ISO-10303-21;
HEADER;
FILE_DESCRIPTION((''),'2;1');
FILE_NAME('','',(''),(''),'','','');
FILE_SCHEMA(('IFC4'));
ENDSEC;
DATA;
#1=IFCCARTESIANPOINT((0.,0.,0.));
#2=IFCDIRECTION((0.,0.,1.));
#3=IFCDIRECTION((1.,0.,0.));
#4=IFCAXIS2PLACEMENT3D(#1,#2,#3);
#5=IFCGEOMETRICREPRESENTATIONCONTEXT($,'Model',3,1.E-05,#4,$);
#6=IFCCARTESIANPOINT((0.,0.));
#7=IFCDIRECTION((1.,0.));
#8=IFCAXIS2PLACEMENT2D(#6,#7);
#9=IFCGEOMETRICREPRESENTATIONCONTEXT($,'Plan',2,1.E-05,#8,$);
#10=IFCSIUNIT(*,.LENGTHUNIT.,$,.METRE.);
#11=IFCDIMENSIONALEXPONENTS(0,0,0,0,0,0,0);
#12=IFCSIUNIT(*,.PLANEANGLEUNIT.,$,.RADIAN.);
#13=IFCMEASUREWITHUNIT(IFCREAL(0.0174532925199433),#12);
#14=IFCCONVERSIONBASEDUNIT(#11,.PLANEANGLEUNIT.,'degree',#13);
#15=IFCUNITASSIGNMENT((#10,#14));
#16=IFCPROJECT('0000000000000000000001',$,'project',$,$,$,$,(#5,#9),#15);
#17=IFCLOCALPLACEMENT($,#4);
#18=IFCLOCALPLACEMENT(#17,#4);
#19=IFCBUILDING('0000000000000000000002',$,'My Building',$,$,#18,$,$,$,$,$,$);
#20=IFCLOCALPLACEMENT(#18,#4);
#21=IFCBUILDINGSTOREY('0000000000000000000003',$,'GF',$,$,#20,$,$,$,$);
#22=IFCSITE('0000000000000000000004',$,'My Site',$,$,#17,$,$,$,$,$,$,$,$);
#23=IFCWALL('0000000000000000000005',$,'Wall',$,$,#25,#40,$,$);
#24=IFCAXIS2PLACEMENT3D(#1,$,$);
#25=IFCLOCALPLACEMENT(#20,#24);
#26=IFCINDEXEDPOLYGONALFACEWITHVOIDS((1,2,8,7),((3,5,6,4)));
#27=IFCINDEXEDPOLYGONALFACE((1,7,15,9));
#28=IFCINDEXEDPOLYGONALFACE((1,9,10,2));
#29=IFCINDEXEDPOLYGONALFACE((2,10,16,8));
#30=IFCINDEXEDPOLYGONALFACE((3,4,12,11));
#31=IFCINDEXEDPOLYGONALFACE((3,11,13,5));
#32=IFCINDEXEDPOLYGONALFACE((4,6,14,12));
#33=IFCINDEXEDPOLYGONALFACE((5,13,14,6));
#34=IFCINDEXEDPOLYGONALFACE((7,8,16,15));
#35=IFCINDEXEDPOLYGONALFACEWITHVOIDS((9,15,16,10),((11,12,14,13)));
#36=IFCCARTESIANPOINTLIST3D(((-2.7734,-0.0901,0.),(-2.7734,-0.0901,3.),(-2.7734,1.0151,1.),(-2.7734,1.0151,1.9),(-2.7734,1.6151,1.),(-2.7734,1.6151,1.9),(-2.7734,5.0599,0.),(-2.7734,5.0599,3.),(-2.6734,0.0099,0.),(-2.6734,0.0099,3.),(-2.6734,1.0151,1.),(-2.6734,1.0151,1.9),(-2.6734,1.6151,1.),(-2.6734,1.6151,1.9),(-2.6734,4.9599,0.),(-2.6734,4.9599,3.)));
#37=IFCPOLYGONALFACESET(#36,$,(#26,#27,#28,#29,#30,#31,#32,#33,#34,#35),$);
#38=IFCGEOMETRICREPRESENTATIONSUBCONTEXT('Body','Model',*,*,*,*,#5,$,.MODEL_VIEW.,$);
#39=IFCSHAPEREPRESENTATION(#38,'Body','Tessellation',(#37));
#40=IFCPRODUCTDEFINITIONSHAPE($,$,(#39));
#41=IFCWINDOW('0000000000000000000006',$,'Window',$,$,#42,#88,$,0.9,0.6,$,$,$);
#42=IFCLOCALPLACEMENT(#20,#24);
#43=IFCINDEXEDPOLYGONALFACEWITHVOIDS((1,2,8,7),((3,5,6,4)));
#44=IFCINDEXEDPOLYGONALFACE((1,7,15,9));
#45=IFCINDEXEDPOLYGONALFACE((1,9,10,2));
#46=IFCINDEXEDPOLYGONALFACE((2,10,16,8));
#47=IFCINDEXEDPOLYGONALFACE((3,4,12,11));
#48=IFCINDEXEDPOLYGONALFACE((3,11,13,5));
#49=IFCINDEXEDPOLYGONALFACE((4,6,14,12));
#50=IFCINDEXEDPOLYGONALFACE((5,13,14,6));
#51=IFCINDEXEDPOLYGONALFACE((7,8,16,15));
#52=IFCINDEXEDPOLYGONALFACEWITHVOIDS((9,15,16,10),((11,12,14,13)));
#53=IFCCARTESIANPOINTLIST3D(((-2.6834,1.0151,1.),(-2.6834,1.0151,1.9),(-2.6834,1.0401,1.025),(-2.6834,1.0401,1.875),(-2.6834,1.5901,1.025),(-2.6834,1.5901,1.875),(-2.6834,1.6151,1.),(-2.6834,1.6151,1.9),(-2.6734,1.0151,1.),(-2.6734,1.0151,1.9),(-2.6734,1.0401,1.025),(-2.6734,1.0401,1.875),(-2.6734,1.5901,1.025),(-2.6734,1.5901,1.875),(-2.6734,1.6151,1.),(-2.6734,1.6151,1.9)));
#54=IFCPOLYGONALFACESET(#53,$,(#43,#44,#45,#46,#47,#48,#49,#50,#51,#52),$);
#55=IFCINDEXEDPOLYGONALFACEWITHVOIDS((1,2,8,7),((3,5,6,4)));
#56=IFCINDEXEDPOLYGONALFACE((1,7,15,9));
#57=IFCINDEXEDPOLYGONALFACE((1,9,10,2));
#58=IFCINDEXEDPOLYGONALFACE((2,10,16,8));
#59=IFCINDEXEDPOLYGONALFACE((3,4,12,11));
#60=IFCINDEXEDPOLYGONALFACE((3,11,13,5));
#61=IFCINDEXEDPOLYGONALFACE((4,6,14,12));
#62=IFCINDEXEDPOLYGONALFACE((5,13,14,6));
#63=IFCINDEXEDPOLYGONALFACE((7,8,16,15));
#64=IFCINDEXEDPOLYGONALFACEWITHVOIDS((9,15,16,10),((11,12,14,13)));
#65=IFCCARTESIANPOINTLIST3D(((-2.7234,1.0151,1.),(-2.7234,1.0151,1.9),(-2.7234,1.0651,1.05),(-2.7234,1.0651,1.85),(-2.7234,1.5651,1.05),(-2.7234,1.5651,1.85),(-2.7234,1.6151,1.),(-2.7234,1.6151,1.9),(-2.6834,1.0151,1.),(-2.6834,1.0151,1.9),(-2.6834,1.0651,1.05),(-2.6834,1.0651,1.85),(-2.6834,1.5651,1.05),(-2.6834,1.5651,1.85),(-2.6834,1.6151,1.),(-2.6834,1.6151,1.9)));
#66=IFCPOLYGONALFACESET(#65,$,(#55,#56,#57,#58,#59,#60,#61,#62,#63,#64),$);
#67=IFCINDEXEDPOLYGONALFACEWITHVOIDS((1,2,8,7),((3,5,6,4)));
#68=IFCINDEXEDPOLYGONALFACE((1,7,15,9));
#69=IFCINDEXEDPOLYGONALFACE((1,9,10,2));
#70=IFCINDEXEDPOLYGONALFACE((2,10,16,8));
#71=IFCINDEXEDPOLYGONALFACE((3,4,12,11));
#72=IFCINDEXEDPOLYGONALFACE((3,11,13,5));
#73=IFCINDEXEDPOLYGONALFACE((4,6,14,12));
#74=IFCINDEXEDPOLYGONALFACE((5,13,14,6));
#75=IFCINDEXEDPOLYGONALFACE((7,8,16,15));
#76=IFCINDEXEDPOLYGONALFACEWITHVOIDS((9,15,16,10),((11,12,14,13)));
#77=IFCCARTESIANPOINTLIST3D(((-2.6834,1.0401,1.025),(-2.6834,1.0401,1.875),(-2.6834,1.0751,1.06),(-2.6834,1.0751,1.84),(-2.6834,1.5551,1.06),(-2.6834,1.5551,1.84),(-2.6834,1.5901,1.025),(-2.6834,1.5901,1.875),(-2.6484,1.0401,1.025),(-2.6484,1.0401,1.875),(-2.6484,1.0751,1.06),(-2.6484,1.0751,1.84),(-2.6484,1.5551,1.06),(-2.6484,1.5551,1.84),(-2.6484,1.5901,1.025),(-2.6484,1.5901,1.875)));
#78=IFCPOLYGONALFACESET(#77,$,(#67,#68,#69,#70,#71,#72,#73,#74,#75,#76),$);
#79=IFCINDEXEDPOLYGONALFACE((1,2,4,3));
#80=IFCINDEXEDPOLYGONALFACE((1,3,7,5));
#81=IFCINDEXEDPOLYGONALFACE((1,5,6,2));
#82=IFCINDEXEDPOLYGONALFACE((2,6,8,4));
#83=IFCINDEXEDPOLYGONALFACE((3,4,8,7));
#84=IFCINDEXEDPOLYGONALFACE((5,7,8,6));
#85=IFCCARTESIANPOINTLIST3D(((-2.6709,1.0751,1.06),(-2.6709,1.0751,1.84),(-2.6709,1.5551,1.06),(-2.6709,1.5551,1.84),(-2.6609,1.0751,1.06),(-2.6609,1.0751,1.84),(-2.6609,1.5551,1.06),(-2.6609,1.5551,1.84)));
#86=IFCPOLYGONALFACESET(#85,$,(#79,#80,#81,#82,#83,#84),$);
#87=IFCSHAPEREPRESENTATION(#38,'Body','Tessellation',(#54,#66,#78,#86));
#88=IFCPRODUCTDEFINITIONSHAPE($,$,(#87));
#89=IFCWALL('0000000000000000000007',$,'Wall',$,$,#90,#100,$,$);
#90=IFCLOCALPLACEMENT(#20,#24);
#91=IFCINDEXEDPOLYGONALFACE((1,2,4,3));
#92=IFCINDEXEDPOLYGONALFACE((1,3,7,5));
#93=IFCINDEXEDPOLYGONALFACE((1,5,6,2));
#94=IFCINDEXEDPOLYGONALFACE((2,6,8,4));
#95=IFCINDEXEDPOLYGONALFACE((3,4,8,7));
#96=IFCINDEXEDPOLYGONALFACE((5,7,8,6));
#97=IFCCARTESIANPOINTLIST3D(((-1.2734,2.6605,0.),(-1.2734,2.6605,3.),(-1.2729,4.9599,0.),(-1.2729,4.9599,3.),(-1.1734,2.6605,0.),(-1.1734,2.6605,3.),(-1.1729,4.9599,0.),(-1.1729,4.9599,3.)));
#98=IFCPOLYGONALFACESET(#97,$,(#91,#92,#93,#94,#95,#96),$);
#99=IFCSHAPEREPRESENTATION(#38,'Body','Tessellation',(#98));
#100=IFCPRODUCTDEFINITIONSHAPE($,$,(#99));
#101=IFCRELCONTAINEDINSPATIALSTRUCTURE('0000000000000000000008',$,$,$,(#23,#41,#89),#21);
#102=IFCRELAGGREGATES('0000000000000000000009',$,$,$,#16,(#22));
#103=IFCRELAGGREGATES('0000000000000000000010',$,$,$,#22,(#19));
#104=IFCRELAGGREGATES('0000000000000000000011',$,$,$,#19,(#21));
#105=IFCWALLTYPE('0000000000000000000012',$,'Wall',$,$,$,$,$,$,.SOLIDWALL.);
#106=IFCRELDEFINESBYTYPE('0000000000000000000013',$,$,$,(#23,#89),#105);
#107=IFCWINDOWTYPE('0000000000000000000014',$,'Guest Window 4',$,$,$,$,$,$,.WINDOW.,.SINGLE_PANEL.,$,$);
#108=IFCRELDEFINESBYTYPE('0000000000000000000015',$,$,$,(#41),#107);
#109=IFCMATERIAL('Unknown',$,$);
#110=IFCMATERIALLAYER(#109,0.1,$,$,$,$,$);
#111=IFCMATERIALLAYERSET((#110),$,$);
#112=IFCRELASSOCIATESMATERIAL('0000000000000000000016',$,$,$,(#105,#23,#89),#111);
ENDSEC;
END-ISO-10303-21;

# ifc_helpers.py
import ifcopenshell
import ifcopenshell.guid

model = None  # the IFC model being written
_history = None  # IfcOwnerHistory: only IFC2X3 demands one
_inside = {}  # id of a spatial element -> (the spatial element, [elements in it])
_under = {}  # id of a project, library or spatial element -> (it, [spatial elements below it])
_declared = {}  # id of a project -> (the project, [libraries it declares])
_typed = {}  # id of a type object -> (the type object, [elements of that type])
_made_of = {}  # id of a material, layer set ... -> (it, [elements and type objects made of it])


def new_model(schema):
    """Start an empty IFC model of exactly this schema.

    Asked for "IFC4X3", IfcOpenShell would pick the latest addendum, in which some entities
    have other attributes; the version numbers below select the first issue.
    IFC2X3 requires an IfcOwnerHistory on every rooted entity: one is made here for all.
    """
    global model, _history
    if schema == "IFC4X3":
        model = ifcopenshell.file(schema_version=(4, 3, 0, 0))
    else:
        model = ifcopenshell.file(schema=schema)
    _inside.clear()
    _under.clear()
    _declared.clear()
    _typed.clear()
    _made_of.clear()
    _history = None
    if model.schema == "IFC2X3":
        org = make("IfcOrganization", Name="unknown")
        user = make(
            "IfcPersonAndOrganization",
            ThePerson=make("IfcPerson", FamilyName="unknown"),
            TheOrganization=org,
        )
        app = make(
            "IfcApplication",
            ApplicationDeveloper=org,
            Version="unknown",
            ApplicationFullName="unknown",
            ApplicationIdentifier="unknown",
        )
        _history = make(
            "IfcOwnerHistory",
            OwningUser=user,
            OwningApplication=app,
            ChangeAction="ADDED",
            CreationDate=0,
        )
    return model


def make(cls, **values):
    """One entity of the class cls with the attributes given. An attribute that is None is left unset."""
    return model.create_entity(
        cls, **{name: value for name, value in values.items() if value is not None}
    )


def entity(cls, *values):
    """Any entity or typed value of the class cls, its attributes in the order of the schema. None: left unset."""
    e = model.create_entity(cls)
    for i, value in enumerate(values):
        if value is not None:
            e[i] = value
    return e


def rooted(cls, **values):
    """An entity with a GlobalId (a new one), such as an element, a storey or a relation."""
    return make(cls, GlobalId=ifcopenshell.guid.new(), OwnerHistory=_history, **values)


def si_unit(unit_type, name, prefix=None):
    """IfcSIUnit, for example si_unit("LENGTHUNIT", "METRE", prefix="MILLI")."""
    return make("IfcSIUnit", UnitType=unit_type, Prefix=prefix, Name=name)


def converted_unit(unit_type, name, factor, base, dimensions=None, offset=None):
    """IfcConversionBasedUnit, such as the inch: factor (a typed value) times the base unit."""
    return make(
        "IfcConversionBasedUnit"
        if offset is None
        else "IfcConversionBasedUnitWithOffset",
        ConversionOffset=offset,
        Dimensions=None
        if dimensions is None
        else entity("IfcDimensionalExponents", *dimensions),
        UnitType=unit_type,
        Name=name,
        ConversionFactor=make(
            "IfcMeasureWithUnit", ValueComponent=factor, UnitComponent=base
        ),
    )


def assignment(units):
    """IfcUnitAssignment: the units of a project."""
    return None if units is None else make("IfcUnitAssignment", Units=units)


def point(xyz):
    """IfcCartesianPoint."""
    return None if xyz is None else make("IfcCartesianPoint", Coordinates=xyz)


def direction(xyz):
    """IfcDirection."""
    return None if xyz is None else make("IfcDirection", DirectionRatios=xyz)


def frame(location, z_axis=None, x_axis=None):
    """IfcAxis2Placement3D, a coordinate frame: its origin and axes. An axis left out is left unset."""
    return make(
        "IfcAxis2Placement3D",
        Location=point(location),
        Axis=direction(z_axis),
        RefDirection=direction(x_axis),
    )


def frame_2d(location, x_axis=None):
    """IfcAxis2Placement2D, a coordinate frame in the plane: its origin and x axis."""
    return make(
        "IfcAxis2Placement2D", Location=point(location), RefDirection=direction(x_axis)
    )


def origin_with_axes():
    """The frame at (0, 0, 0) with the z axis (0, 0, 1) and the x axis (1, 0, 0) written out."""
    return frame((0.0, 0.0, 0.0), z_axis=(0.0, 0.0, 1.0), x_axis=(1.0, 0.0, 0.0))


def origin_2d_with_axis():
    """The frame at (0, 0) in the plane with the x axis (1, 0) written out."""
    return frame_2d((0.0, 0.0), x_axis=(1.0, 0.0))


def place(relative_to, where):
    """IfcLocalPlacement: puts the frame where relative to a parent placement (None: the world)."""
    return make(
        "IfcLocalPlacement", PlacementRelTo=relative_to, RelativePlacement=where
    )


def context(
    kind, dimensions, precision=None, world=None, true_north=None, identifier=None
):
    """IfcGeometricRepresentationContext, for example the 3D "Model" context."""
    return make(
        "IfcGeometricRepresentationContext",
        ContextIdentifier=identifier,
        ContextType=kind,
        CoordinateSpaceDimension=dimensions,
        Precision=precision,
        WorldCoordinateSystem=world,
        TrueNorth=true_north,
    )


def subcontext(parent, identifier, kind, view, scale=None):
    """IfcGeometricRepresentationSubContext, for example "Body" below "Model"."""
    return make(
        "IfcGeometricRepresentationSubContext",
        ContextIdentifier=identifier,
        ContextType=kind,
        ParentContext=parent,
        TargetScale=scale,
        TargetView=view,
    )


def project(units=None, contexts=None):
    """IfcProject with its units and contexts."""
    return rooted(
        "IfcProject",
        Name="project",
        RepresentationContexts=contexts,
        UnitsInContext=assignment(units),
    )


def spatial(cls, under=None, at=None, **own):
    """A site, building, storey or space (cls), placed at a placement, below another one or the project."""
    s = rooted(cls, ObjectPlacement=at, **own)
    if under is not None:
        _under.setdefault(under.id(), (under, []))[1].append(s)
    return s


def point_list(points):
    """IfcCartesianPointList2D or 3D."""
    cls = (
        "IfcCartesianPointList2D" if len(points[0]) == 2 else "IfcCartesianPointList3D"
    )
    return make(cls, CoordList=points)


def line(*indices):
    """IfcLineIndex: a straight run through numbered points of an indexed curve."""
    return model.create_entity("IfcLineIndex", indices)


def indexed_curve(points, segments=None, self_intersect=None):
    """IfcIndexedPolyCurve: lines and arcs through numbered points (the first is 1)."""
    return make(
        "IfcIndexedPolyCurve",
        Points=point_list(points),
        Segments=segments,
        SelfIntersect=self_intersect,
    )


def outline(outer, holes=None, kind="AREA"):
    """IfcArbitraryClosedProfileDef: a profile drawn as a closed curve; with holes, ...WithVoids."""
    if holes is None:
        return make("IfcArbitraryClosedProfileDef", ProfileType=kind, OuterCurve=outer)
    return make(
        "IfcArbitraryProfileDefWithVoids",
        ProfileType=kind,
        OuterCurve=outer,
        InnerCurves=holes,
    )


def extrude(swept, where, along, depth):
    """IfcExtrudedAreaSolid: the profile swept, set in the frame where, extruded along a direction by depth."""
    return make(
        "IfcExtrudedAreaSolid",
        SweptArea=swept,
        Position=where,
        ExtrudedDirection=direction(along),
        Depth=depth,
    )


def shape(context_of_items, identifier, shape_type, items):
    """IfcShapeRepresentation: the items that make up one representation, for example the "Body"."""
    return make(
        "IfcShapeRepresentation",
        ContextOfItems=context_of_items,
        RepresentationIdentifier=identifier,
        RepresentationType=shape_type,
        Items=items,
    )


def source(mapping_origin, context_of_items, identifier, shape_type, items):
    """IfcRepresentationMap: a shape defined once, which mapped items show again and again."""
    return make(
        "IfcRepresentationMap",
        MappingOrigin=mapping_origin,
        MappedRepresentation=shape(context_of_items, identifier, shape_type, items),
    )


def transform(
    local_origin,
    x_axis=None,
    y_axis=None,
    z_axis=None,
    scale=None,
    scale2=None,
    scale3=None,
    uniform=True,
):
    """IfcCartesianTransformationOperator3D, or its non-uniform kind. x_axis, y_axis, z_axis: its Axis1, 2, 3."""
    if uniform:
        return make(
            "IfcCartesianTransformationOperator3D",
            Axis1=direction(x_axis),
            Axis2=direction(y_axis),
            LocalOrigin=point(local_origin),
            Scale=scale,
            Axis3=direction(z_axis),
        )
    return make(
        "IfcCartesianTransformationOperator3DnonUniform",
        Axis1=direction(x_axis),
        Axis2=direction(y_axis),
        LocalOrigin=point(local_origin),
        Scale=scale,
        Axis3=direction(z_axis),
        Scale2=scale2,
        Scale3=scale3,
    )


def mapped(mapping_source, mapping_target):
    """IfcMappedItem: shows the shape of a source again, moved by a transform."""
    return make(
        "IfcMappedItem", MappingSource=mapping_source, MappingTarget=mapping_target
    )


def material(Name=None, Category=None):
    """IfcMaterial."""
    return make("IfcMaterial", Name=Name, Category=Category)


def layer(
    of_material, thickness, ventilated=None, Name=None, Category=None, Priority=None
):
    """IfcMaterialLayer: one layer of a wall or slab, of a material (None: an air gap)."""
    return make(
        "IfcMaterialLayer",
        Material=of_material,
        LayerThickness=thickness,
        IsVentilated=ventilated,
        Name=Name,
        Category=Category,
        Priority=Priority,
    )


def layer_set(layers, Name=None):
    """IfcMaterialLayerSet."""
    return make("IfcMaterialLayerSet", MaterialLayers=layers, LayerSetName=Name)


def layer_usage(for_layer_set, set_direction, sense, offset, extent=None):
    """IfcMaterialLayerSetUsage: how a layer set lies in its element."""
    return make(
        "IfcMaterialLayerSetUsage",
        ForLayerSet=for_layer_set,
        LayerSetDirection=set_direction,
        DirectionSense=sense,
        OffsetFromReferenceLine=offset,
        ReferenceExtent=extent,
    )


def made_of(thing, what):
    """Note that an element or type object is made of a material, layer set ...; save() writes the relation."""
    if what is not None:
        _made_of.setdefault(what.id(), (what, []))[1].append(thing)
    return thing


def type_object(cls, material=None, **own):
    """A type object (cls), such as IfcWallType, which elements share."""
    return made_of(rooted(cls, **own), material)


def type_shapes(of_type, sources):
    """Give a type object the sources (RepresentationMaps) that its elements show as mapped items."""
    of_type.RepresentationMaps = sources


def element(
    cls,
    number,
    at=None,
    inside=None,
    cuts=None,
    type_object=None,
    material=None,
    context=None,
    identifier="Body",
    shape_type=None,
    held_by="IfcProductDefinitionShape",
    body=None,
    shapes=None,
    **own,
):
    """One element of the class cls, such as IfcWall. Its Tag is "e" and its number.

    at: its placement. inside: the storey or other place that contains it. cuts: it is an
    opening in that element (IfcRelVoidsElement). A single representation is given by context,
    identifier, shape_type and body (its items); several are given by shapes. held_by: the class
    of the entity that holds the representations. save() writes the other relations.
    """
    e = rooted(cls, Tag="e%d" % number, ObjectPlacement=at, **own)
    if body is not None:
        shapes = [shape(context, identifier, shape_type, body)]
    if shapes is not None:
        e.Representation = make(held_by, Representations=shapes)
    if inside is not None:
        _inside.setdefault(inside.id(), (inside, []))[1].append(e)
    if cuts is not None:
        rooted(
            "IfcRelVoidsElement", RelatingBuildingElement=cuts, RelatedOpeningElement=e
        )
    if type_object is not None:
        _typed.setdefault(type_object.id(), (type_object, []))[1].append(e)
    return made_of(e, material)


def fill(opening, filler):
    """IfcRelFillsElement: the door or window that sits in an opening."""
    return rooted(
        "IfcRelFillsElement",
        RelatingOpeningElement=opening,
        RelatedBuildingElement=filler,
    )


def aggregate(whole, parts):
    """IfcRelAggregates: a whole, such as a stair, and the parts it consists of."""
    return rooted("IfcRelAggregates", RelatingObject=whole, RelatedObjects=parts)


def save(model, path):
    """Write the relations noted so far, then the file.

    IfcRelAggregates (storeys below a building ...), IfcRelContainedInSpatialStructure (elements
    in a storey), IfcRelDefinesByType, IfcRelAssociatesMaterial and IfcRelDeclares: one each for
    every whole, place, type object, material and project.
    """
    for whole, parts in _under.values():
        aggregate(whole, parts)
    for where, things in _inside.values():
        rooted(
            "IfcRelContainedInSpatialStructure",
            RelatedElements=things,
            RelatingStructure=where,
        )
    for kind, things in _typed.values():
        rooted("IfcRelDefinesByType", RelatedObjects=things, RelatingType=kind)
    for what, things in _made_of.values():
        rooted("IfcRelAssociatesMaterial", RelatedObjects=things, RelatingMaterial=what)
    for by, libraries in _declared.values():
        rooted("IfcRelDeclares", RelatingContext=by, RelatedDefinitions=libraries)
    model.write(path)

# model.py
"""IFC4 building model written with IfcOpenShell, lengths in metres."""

from ifc_helpers import new_model, entity, si_unit, converted_unit, frame, origin_with_axes, origin_2d_with_axis, place, context, subcontext, project, spatial, line, indexed_curve, outline, extrude, shape, source, transform, mapped, material, layer, layer_set, layer_usage, type_object, type_shapes, element, fill, save


model = new_model("IFC4")

# Units and contexts
model_context = context("Model", 3, precision=1e-05, world=origin_with_axes())
plan_context = context("Plan", 2, precision=1e-05, world=origin_2d_with_axis())
body_context_1 = subcontext(model_context, "Body", "Model", "MODEL_VIEW")
body_context_2 = subcontext(plan_context, "Body", "Plan", "PLAN_VIEW")
ifc_project = project(units=[si_unit("LENGTHUNIT", "METRE"), converted_unit("PLANEANGLEUNIT", "degree", entity("IfcReal", 0.0174532925199433), si_unit("PLANEANGLEUNIT", "RADIAN"), dimensions=[0, 0, 0, 0, 0, 0, 0])], contexts=[model_context, plan_context])

# Site, building, storey
site_placement = place(None, origin_with_axes())
site = spatial("IfcSite", under=ifc_project, at=site_placement, Name="My Site")
building_placement = place(site_placement, origin_with_axes())
building = spatial("IfcBuilding", under=site, at=building_placement, Name="My Building")
storey_placement = place(building_placement, origin_with_axes())
storey = spatial("IfcBuildingStorey", under=building, at=storey_placement, Name="GF")

# Shared definitions
ifc_material = material(Name="Unknown")

# Shared definitions
ifc_layer = layer(ifc_material, 0.1)
ifc_layer_set = layer_set([ifc_layer])
wall_type = type_object("IfcWallType", Name="Wall", PredefinedType="SOLIDWALL", material=ifc_layer_set)

# Wall, opening, window
ifc_layer_usage_1 = layer_usage(ifc_layer_set, "AXIS2", "POSITIVE", 0.0)
wall_1_placement = place(storey_placement, frame((-2.7734, 5.0599, 0.0), z_axis=(0.0, 0.0, 1.0), x_axis=(0.0, -1.0, 0.0)))
wall_1 = element("IfcWall", 1, at=wall_1_placement, inside=storey, type_object=wall_type, material=ifc_layer_usage_1, Name="Wall", context=body_context_1, shape_type="SweptSolid", body=[
    extrude(outline(indexed_curve([(0.0, 0.0), (0.1, 0.1), (5.05, 0.1), (5.15, 0.0)], segments=[line(1, 2, 3, 4, 1)])), origin_with_axes(), (0.0, 0.0, 1.0), 3.0),
])
shared_shape_1 = source(origin_with_axes(), body_context_1, "Body", "SweptSolid", [
    extrude(outline(indexed_curve([(0.0, 0.0), (0.6, 0.0), (0.6, 0.9), (0.0, 0.9)], segments=[line(1, 2, 3, 4, 1)])), frame((0.0, -0.6, 0.0), z_axis=(0.0, -1.0, 0.0), x_axis=(1.0, 0.0, 0.0)), (0.0, 0.0, -1.0), 1.2),
])
opening_1_placement = place(wall_1_placement, frame((3.4448, 0.0, 1.0), z_axis=(0.0, 0.0, 1.0), x_axis=(1.0, 0.0, 0.0)))
opening_1 = element("IfcOpeningElement", 2, at=opening_1_placement, cuts=wall_1, PredefinedType="OPENING", context=body_context_1, shape_type="MappedRepresentation", body=[
    mapped(shared_shape_1, transform((0.0, 0.0, 0.0), x_axis=(1.0, 0.0, 0.0), y_axis=(0.0, 1.0, 0.0), z_axis=(0.0, 0.0, 1.0), scale=1.0)),
])
window_type_1 = type_object("IfcWindowType", Name="Guest Window 4", PartitioningType="SINGLE_PANEL", PredefinedType="WINDOW")
shared_shape_2 = source(origin_with_axes(), body_context_1, "Body", "SweptSolid", [
    extrude(outline(indexed_curve([(0.0, 0.0), (0.6, 0.0), (0.6, 0.9), (0.0, 0.9)], segments=[line(1, 2, 3, 4, 1)]), holes=[indexed_curve([(0.025, 0.025), (0.575, 0.025), (0.575, 0.875), (0.025, 0.875)], segments=[line(1, 2, 3, 4, 1)])]), frame((0.0, 0.09, 0.0), z_axis=(0.0, -1.0, 0.0), x_axis=(1.0, 0.0, 0.0)), (0.0, 0.0, -1.0), 0.01),
    extrude(outline(indexed_curve([(0.0, 0.0), (0.6, 0.0), (0.6, 0.9), (0.0, 0.9)], segments=[line(1, 2, 3, 4, 1)]), holes=[indexed_curve([(0.05, 0.05), (0.55, 0.05), (0.55, 0.85), (0.05, 0.85)], segments=[line(1, 2, 3, 4, 1)])]), frame((0.0, 0.05, 0.0), z_axis=(0.0, -1.0, 0.0), x_axis=(1.0, 0.0, 0.0)), (0.0, 0.0, -1.0), 0.04),
    extrude(outline(indexed_curve([(0.0, 0.0), (0.55, 0.0), (0.55, 0.85), (0.0, 0.85)], segments=[line(1, 2, 3, 4, 1)]), holes=[indexed_curve([(0.035, 0.035), (0.515, 0.035), (0.515, 0.815), (0.035, 0.815)], segments=[line(1, 2, 3, 4, 1)])]), frame((0.025, 0.09, 0.025), z_axis=(0.0, -1.0, 0.0), x_axis=(1.0, 0.0, 0.0)), (0.0, 0.0, -1.0), 0.035),
    extrude(outline(indexed_curve([(0.035, 0.035), (0.515, 0.035), (0.515, 0.815), (0.035, 0.815)], segments=[line(1, 2, 3, 4, 1)])), frame((0.025, 0.1025, 0.025), z_axis=(0.0, -1.0, 0.0), x_axis=(1.0, 0.0, 0.0)), (0.0, 0.0, -1.0), 0.01),
])
shared_shape_3 = source(origin_with_axes(), body_context_2, "Body", "Curve2D", [
    entity("IfcIndexedPolyCurve", entity("IfcCartesianPointList2D", [[0.05, 0.05], [0.55, 0.05]])),
    entity("IfcIndexedPolyCurve", entity("IfcCartesianPointList2D", [[0.0, 0.1], [0.025, 0.1], [0.025, 0.09], [0.05, 0.09], [0.05, 0.05], [0.0, 0.05]]), [entity("IfcLineIndex", [1, 2, 3, 4, 5, 6, 1])]),
    entity("IfcIndexedPolyCurve", entity("IfcCartesianPointList2D", [[0.6, 0.1], [0.575, 0.1], [0.575, 0.09], [0.55, 0.09], [0.55, 0.05], [0.6, 0.05]]), [entity("IfcLineIndex", [1, 2, 3, 4, 5, 6, 1])]),
    entity("IfcIndexedPolyCurve", entity("IfcCartesianPointList2D", [[0.025, 0.09], [0.06, 0.09], [0.06, 0.125], [0.025, 0.125]]), [entity("IfcLineIndex", [1, 2, 3, 4, 1])]),
    entity("IfcIndexedPolyCurve", entity("IfcCartesianPointList2D", [[0.575, 0.09], [0.54, 0.09], [0.54, 0.125], [0.575, 0.125]]), [entity("IfcLineIndex", [1, 2, 3, 4, 1])]),
    entity("IfcIndexedPolyCurve", entity("IfcCartesianPointList2D", [[0.06, 0.09], [0.54, 0.09]])),
    entity("IfcIndexedPolyCurve", entity("IfcCartesianPointList2D", [[0.06, 0.125], [0.54, 0.125]])),
    entity("IfcIndexedPolyCurve", entity("IfcCartesianPointList2D", [[0.06, 0.1075], [0.54, 0.1075]])),
])
type_shapes(window_type_1, [shared_shape_2, shared_shape_3])
window_1_placement = place(opening_1_placement, frame((0.0, 0.0, 0.0), z_axis=(0.0, 0.0, 1.0), x_axis=(1.0, 0.0, 0.0)))
window_1 = element("IfcWindow", 3, at=window_1_placement, inside=storey, type_object=window_type_1, Name="Window", OverallHeight=0.9, OverallWidth=0.6, shapes=[
    shape(body_context_1, "Body", "MappedRepresentation", [mapped(shared_shape_2, transform((0.0, 0.0, 0.0), x_axis=(1.0, 0.0, 0.0), y_axis=(0.0, 1.0, 0.0), z_axis=(0.0, 0.0, 1.0), scale=1.0))]),
    shape(body_context_2, "Body", "MappedRepresentation", [mapped(shared_shape_3, transform((0.0, 0.0, 0.0), x_axis=(1.0, 0.0, 0.0), y_axis=(0.0, 1.0, 0.0), z_axis=(0.0, 0.0, 1.0), scale=1.0))]),
])
fill(opening_1, window_1)

# Wall
ifc_layer_usage_2 = layer_usage(ifc_layer_set, "AXIS2", "POSITIVE", 0.0)
wall_2_placement = place(storey_placement, frame((-1.1734, 2.6605, 0.0), z_axis=(0.0, 0.0, 1.0), x_axis=(0.000197, 1.0, 0.0)))
element("IfcWall", 4, at=wall_2_placement, inside=storey, type_object=wall_type, material=ifc_layer_usage_2, Name="Wall", context=body_context_1, shape_type="SweptSolid", body=[
    extrude(outline(indexed_curve([(0.0, 0.0), (0.0, 0.1), (2.2994, 0.1), (2.2994, 0.0)], segments=[line(1, 2, 3, 4, 1)])), origin_with_axes(), (0.0, 0.0, 1.0), 3.0),
])

save(model, "model.ifc")
